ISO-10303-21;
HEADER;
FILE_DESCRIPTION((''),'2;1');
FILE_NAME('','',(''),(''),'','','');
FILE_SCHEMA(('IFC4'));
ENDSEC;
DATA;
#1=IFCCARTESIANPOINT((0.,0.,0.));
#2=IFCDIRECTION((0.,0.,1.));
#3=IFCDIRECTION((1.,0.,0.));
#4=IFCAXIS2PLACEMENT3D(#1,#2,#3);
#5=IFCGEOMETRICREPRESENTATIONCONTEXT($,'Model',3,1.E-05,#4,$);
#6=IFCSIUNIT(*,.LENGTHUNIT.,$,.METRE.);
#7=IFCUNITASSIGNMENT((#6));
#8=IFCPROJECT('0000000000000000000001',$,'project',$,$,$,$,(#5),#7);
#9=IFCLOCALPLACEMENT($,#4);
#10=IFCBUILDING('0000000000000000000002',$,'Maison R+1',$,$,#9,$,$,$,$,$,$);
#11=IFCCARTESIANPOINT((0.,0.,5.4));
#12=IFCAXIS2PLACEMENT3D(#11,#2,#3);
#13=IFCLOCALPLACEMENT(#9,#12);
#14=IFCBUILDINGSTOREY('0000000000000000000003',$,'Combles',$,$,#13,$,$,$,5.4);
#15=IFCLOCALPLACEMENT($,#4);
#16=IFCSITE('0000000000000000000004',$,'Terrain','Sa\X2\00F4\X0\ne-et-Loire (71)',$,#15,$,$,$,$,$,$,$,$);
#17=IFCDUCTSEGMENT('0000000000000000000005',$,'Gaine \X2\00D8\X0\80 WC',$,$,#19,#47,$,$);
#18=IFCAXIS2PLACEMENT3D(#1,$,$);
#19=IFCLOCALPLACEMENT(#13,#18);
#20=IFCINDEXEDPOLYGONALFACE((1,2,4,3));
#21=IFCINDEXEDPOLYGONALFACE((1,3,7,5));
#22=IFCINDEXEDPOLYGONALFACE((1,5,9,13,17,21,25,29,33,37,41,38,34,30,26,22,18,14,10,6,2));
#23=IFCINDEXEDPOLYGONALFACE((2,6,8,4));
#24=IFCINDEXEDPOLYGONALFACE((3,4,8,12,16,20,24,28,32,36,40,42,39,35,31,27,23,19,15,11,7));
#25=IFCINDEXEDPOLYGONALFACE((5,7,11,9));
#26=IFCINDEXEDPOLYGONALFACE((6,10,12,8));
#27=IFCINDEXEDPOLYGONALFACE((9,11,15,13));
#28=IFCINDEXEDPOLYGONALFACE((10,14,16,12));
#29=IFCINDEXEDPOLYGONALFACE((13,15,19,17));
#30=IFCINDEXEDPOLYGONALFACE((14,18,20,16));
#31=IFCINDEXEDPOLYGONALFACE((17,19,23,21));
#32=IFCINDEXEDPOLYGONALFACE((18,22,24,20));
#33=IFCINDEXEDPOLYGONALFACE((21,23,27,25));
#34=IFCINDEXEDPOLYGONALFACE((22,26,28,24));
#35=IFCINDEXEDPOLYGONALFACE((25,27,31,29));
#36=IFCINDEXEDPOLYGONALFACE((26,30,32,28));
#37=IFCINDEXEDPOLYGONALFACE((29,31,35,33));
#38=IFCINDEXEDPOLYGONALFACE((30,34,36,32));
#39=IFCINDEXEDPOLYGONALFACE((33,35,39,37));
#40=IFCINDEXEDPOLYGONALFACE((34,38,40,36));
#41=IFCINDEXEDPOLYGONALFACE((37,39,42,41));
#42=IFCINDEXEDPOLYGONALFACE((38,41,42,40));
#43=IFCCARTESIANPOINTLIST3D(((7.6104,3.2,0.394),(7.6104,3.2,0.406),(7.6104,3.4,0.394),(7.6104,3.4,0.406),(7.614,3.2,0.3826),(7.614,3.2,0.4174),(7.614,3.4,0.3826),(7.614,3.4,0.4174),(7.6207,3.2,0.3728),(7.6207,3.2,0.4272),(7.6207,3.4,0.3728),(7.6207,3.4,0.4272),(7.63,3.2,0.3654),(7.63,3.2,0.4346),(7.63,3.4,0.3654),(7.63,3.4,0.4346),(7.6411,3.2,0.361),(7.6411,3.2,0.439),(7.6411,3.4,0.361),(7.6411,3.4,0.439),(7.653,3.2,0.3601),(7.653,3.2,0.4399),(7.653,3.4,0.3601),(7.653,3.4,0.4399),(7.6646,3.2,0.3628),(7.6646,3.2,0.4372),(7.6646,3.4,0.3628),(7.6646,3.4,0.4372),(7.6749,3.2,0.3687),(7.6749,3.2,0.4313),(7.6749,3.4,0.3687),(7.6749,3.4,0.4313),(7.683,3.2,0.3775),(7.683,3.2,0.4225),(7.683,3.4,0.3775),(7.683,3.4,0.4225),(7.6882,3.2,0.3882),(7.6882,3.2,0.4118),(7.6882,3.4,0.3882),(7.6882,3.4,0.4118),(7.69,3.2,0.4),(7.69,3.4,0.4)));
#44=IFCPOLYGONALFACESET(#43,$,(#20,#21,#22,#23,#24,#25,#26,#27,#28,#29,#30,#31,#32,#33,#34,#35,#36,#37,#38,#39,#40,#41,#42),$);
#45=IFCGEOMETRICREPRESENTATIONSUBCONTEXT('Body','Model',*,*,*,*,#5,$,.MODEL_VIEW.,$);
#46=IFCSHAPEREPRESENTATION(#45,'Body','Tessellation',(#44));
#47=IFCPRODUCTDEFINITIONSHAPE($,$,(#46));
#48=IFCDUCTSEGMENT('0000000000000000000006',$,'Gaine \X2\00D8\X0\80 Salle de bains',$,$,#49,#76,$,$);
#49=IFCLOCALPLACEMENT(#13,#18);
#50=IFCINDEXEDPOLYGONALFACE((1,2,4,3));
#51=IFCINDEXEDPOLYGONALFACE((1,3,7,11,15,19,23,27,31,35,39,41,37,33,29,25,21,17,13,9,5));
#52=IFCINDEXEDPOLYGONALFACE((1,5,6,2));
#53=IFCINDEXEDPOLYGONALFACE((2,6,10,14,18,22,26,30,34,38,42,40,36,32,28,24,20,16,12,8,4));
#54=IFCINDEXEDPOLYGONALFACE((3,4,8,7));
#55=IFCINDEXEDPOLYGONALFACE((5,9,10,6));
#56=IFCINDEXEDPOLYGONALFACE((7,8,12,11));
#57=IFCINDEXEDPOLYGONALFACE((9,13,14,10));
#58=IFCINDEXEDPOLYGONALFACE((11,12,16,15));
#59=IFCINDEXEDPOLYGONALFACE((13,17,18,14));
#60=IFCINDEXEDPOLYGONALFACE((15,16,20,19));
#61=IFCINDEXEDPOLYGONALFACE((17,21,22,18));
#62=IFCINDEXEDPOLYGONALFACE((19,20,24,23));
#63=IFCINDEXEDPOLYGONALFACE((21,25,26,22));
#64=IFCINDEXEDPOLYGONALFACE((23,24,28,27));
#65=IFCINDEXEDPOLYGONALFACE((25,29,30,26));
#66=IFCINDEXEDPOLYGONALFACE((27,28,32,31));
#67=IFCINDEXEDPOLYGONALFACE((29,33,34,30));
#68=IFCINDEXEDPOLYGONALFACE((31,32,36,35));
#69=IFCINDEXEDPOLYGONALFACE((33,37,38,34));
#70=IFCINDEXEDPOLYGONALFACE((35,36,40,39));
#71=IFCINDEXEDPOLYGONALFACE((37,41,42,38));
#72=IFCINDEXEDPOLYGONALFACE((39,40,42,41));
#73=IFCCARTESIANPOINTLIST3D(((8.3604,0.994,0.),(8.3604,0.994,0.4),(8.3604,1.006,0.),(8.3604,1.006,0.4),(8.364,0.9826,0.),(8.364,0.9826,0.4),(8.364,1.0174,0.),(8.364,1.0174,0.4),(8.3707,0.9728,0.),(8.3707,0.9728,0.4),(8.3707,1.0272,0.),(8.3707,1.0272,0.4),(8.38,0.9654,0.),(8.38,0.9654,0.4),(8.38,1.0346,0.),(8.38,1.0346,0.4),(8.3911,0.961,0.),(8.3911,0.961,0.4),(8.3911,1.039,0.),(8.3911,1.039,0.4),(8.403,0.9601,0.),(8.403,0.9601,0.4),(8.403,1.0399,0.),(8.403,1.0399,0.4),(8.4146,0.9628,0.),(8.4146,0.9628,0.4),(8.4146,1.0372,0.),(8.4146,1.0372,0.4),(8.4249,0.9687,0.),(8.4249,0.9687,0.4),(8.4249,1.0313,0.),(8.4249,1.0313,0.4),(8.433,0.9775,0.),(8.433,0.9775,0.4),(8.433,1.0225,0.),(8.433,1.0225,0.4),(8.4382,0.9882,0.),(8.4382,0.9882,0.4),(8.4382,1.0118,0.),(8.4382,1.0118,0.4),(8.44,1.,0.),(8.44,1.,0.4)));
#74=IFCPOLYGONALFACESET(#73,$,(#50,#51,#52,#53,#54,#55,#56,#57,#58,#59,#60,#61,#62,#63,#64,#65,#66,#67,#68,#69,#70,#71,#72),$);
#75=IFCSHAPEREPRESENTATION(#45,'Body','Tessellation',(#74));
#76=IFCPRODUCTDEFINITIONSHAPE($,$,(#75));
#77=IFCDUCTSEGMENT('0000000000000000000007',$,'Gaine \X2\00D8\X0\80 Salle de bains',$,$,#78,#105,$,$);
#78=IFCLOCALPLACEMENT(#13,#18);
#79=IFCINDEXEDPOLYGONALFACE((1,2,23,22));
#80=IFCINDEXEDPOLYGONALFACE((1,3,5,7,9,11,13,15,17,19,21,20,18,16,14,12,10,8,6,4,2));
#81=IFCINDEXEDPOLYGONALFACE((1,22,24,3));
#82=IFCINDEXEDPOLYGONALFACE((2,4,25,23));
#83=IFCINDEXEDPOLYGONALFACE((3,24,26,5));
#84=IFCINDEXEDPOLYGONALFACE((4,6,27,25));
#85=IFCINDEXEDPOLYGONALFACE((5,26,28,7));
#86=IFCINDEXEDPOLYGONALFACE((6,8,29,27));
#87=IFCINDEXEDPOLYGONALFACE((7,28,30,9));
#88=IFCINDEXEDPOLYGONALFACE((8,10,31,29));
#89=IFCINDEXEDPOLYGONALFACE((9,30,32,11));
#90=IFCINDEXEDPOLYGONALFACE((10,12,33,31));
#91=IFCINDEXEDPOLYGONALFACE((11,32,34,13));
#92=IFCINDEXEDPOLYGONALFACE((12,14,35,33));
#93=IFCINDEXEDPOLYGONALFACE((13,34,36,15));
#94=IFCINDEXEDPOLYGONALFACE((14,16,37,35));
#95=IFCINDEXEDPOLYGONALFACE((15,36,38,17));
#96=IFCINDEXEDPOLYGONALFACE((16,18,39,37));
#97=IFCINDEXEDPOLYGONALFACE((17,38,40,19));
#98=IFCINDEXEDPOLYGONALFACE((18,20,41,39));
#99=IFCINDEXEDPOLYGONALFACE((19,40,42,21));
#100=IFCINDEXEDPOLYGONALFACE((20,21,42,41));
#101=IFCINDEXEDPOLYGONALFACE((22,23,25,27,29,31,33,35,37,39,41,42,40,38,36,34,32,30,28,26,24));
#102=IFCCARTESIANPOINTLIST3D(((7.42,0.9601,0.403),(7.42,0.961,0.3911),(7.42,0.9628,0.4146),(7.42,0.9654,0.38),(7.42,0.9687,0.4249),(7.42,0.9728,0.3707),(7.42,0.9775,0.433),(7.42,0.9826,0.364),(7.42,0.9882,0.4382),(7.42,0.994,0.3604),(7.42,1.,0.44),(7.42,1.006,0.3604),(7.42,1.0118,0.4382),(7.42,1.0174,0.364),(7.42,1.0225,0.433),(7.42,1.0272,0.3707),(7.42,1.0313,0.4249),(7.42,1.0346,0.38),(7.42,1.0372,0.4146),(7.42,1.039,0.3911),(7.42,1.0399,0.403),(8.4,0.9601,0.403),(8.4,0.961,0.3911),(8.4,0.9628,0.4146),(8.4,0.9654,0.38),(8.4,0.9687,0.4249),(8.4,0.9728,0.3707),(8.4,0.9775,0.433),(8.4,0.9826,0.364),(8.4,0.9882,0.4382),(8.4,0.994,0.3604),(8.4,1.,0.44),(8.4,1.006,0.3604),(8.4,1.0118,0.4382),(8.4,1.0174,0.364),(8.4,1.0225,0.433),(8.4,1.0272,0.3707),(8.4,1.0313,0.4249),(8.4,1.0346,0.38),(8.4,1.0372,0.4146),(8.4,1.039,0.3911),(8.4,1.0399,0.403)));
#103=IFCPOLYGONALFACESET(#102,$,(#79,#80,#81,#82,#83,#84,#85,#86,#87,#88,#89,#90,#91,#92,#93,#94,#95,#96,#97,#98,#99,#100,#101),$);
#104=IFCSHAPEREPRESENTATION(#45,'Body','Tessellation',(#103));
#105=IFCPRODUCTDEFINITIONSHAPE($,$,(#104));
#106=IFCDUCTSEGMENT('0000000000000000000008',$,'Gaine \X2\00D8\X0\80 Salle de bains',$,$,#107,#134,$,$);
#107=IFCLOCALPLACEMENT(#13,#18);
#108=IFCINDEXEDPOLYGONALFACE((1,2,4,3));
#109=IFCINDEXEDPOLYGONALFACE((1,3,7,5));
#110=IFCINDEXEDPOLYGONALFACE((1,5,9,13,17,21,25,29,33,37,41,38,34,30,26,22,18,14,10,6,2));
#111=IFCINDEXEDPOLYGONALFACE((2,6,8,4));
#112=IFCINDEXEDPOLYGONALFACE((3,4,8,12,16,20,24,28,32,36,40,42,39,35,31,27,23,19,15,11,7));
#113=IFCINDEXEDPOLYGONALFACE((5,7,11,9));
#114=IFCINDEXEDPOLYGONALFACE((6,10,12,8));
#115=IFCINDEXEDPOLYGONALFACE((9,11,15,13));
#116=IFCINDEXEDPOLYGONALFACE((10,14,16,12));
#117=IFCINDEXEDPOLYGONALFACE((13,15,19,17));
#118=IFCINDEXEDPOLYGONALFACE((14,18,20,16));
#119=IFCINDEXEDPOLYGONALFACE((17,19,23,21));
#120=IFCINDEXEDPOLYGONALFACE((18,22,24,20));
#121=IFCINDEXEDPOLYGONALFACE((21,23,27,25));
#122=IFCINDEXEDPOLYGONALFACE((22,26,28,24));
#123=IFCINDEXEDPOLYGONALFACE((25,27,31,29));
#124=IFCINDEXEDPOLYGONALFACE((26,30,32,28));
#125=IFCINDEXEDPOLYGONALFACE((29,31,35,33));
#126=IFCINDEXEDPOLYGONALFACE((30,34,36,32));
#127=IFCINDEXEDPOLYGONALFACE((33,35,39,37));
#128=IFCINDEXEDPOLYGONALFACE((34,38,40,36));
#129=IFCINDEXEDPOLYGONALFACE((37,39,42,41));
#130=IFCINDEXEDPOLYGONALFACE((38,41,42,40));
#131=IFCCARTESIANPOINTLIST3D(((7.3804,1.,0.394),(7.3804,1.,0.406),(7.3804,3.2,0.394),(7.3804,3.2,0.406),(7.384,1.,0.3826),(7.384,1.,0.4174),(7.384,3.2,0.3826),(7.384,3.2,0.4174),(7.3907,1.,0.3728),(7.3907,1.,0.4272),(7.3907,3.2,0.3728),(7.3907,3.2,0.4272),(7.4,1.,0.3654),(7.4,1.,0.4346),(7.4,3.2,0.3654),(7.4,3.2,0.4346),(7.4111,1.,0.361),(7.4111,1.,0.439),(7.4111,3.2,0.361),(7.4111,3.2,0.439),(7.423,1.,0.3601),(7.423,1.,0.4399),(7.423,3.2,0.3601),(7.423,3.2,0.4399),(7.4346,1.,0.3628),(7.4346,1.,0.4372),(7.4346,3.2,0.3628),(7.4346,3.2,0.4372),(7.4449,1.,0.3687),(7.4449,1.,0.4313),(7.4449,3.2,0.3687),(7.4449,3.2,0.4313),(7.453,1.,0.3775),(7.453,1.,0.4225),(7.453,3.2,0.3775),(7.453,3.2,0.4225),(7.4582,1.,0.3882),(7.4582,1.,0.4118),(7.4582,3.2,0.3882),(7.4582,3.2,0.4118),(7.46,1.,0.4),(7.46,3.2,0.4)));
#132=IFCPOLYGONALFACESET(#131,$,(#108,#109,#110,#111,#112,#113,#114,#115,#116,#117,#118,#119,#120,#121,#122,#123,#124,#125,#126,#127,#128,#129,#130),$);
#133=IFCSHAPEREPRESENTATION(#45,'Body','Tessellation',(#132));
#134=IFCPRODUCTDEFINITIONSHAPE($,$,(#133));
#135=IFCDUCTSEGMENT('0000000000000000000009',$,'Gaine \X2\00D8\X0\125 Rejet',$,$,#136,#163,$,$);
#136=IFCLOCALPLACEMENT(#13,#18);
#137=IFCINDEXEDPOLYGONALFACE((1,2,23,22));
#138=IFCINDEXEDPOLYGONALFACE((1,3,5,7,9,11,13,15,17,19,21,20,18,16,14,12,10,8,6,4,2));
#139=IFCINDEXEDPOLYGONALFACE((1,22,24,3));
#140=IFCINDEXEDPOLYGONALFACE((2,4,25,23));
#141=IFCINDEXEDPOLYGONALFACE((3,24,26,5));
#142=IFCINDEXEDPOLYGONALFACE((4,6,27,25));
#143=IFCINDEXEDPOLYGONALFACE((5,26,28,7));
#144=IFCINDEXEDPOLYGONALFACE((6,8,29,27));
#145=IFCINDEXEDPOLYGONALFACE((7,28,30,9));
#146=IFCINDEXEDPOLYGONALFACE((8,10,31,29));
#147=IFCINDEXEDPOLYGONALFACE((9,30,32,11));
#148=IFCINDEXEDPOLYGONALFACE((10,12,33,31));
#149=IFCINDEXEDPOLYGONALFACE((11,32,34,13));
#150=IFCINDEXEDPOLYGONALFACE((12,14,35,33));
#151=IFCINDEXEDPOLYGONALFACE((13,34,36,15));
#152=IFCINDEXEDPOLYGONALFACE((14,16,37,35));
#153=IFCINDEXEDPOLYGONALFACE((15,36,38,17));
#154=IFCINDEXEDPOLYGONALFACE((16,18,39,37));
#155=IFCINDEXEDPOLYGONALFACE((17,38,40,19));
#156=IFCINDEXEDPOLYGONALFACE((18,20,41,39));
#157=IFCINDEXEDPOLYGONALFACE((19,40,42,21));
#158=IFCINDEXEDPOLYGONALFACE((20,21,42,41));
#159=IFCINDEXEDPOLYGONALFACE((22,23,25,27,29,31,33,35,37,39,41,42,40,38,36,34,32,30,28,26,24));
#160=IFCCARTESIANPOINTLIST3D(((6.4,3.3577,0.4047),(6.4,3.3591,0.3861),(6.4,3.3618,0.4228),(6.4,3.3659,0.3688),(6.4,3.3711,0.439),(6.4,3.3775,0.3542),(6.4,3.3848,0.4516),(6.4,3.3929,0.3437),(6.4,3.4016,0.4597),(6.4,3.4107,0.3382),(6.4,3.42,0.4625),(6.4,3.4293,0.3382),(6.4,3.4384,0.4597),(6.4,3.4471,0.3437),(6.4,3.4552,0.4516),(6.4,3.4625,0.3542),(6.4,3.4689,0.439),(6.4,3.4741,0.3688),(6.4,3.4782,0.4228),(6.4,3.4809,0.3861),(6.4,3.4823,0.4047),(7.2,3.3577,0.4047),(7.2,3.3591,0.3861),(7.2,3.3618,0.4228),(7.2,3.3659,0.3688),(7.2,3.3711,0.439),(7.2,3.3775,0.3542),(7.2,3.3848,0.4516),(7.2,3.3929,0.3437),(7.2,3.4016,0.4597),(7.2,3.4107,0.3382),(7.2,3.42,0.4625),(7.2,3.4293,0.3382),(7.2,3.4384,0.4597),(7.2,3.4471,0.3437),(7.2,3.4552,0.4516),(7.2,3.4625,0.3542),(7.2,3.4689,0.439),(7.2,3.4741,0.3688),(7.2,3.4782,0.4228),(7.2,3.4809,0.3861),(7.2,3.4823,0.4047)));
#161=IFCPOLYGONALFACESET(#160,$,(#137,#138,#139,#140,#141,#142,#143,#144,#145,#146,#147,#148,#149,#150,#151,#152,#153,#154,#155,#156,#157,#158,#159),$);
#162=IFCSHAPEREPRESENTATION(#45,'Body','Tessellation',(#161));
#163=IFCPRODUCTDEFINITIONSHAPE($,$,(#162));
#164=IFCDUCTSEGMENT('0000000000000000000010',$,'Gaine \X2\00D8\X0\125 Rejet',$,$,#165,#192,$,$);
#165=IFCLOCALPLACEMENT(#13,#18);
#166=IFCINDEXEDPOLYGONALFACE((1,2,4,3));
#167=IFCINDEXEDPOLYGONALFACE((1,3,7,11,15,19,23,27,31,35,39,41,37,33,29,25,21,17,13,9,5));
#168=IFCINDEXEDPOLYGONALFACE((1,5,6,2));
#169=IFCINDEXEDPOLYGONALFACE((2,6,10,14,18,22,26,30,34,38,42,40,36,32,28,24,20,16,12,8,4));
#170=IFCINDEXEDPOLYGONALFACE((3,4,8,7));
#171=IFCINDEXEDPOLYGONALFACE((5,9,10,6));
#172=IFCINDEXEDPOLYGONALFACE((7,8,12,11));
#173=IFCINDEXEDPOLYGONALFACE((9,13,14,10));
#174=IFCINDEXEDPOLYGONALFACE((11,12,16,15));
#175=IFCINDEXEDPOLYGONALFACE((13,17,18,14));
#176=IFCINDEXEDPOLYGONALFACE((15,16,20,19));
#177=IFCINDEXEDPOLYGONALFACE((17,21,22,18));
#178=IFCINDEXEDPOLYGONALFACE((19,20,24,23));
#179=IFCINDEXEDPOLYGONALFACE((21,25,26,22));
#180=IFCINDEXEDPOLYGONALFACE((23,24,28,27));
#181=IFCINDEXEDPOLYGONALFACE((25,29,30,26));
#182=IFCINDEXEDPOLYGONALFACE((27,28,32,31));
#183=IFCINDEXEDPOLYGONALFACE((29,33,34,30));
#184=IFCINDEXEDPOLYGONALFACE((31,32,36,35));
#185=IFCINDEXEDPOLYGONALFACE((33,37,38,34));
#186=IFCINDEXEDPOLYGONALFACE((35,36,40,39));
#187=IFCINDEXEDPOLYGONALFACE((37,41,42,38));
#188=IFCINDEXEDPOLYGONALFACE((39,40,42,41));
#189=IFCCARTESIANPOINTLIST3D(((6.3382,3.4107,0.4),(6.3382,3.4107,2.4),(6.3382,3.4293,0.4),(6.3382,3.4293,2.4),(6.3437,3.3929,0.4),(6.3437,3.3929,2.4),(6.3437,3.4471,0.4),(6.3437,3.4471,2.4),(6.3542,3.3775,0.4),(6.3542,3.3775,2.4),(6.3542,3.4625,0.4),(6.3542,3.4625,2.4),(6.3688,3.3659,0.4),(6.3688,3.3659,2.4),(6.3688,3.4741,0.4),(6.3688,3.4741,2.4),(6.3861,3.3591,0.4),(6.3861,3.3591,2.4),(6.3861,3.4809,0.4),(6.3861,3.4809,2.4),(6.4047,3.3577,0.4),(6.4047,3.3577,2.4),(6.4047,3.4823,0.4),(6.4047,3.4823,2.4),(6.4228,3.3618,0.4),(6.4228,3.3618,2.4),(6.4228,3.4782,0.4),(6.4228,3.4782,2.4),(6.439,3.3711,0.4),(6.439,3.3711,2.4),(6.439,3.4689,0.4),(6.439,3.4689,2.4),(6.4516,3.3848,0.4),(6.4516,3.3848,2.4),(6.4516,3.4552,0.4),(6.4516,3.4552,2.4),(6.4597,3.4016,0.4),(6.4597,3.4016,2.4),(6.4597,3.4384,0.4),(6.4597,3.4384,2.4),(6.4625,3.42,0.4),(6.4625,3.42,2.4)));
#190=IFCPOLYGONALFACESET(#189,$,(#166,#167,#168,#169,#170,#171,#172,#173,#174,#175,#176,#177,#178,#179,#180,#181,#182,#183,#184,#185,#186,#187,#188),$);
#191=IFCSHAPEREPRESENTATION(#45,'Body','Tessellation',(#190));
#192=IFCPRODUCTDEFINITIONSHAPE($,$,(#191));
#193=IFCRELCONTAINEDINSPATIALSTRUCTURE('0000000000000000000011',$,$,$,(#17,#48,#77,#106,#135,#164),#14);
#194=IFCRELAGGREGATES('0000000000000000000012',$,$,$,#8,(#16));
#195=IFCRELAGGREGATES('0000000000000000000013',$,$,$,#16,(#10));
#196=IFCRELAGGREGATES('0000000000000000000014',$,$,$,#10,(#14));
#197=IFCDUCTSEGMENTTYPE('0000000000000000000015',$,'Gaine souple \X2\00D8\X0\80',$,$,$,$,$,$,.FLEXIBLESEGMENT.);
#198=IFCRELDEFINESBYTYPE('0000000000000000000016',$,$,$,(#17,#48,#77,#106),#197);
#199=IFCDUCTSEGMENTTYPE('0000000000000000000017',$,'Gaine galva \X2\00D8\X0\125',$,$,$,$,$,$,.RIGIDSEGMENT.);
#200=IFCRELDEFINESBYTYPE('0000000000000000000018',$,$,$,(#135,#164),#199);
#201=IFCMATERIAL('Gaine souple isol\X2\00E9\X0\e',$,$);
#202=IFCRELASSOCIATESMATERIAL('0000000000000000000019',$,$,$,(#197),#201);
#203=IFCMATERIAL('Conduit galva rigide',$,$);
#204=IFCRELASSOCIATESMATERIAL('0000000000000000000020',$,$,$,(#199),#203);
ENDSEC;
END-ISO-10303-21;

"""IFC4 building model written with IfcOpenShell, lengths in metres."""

from ifc_helpers import new_model, si_unit, frame, origin_with_axes, place, context, subcontext, project, spatial, circle, extrude, material, type_object, element, save


model = new_model("IFC4")

# Units and contexts
model_context = context("Model", 3, precision=1e-05, world=origin_with_axes())
body_context = subcontext(model_context, "Body", "Model", "MODEL_VIEW")
ifc_project = project(units=[si_unit("LENGTHUNIT", "METRE")], contexts=[model_context])

# Site, building, storey
site_placement = place(None, origin_with_axes())
site = spatial("IfcSite", under=ifc_project, at=site_placement, Name="Terrain", Description="Saône-et-Loire (71)")
building_placement = place(None, origin_with_axes())
building = spatial("IfcBuilding", under=site, at=building_placement, Name="Maison R+1")
storey_placement = place(building_placement, frame((0.0, 0.0, 5.4), z_axis=(0.0, 0.0, 1.0), x_axis=(1.0, 0.0, 0.0)))
storey = spatial("IfcBuildingStorey", under=building, at=storey_placement, Name="Combles", Elevation=5.4)

# Duct segments
ifc_material_1 = material(Name="Gaine souple isolée")
duct_segment_type_1 = type_object("IfcDuctSegmentType", Name="Gaine souple Ø80", PredefinedType="FLEXIBLESEGMENT", material=ifc_material_1)
duct_segment_1_placement = place(storey_placement, frame((7.65, 3.2, 0.4), z_axis=(0.0, 1.0, 0.0), x_axis=(1.0, 0.0, 0.0)))
element("IfcDuctSegment", 1, at=duct_segment_1_placement, inside=storey, type_object=duct_segment_type_1, Name="Gaine Ø80 WC", context=body_context, shape_type="SweptSolid", body=[
    extrude(circle(Radius=0.04), origin_with_axes(), (0.0, 0.0, 1.0), 0.2),
])
duct_segment_2_placement = place(storey_placement, frame((8.4, 1.0, 0.0), z_axis=(0.0, 0.0, 1.0), x_axis=(1.0, 0.0, 0.0)))
element("IfcDuctSegment", 2, at=duct_segment_2_placement, inside=storey, type_object=duct_segment_type_1, Name="Gaine Ø80 Salle de bains", context=body_context, shape_type="SweptSolid", body=[
    extrude(circle(Radius=0.04), origin_with_axes(), (0.0, 0.0, 1.0), 0.4),
])
duct_segment_3_placement = place(storey_placement, frame((8.4, 1.0, 0.4), z_axis=(-1.0, 0.0, 0.0), x_axis=(0.0, 0.0, 1.0)))
element("IfcDuctSegment", 3, at=duct_segment_3_placement, inside=storey, type_object=duct_segment_type_1, Name="Gaine Ø80 Salle de bains", context=body_context, shape_type="SweptSolid", body=[
    extrude(circle(Radius=0.04), origin_with_axes(), (0.0, 0.0, 1.0), 0.98),
])
duct_segment_4_placement = place(storey_placement, frame((7.42, 1.0, 0.4), z_axis=(0.0, 1.0, 0.0), x_axis=(1.0, 0.0, 0.0)))
element("IfcDuctSegment", 4, at=duct_segment_4_placement, inside=storey, type_object=duct_segment_type_1, Name="Gaine Ø80 Salle de bains", context=body_context, shape_type="SweptSolid", body=[
    extrude(circle(Radius=0.04), origin_with_axes(), (0.0, 0.0, 1.0), 2.2),
])
ifc_material_2 = material(Name="Conduit galva rigide")
duct_segment_type_2 = type_object("IfcDuctSegmentType", Name="Gaine galva Ø125", PredefinedType="RIGIDSEGMENT", material=ifc_material_2)
duct_segment_5_placement = place(storey_placement, frame((7.2, 3.42, 0.4), z_axis=(-1.0, 0.0, 0.0), x_axis=(0.0, 0.0, 1.0)))
element("IfcDuctSegment", 5, at=duct_segment_5_placement, inside=storey, type_object=duct_segment_type_2, Name="Gaine Ø125 Rejet", context=body_context, shape_type="SweptSolid", body=[
    extrude(circle(Radius=0.0625), origin_with_axes(), (0.0, 0.0, 1.0), 0.8),
])
duct_segment_6_placement = place(storey_placement, frame((6.4, 3.42, 0.4), z_axis=(0.0, 0.0, 1.0), x_axis=(1.0, 0.0, 0.0)))
element("IfcDuctSegment", 6, at=duct_segment_6_placement, inside=storey, type_object=duct_segment_type_2, Name="Gaine Ø125 Rejet", context=body_context, shape_type="SweptSolid", body=[
    extrude(circle(Radius=0.0625), origin_with_axes(), (0.0, 0.0, 1.0), 2.0),
])

save(model, "model.ifc")
